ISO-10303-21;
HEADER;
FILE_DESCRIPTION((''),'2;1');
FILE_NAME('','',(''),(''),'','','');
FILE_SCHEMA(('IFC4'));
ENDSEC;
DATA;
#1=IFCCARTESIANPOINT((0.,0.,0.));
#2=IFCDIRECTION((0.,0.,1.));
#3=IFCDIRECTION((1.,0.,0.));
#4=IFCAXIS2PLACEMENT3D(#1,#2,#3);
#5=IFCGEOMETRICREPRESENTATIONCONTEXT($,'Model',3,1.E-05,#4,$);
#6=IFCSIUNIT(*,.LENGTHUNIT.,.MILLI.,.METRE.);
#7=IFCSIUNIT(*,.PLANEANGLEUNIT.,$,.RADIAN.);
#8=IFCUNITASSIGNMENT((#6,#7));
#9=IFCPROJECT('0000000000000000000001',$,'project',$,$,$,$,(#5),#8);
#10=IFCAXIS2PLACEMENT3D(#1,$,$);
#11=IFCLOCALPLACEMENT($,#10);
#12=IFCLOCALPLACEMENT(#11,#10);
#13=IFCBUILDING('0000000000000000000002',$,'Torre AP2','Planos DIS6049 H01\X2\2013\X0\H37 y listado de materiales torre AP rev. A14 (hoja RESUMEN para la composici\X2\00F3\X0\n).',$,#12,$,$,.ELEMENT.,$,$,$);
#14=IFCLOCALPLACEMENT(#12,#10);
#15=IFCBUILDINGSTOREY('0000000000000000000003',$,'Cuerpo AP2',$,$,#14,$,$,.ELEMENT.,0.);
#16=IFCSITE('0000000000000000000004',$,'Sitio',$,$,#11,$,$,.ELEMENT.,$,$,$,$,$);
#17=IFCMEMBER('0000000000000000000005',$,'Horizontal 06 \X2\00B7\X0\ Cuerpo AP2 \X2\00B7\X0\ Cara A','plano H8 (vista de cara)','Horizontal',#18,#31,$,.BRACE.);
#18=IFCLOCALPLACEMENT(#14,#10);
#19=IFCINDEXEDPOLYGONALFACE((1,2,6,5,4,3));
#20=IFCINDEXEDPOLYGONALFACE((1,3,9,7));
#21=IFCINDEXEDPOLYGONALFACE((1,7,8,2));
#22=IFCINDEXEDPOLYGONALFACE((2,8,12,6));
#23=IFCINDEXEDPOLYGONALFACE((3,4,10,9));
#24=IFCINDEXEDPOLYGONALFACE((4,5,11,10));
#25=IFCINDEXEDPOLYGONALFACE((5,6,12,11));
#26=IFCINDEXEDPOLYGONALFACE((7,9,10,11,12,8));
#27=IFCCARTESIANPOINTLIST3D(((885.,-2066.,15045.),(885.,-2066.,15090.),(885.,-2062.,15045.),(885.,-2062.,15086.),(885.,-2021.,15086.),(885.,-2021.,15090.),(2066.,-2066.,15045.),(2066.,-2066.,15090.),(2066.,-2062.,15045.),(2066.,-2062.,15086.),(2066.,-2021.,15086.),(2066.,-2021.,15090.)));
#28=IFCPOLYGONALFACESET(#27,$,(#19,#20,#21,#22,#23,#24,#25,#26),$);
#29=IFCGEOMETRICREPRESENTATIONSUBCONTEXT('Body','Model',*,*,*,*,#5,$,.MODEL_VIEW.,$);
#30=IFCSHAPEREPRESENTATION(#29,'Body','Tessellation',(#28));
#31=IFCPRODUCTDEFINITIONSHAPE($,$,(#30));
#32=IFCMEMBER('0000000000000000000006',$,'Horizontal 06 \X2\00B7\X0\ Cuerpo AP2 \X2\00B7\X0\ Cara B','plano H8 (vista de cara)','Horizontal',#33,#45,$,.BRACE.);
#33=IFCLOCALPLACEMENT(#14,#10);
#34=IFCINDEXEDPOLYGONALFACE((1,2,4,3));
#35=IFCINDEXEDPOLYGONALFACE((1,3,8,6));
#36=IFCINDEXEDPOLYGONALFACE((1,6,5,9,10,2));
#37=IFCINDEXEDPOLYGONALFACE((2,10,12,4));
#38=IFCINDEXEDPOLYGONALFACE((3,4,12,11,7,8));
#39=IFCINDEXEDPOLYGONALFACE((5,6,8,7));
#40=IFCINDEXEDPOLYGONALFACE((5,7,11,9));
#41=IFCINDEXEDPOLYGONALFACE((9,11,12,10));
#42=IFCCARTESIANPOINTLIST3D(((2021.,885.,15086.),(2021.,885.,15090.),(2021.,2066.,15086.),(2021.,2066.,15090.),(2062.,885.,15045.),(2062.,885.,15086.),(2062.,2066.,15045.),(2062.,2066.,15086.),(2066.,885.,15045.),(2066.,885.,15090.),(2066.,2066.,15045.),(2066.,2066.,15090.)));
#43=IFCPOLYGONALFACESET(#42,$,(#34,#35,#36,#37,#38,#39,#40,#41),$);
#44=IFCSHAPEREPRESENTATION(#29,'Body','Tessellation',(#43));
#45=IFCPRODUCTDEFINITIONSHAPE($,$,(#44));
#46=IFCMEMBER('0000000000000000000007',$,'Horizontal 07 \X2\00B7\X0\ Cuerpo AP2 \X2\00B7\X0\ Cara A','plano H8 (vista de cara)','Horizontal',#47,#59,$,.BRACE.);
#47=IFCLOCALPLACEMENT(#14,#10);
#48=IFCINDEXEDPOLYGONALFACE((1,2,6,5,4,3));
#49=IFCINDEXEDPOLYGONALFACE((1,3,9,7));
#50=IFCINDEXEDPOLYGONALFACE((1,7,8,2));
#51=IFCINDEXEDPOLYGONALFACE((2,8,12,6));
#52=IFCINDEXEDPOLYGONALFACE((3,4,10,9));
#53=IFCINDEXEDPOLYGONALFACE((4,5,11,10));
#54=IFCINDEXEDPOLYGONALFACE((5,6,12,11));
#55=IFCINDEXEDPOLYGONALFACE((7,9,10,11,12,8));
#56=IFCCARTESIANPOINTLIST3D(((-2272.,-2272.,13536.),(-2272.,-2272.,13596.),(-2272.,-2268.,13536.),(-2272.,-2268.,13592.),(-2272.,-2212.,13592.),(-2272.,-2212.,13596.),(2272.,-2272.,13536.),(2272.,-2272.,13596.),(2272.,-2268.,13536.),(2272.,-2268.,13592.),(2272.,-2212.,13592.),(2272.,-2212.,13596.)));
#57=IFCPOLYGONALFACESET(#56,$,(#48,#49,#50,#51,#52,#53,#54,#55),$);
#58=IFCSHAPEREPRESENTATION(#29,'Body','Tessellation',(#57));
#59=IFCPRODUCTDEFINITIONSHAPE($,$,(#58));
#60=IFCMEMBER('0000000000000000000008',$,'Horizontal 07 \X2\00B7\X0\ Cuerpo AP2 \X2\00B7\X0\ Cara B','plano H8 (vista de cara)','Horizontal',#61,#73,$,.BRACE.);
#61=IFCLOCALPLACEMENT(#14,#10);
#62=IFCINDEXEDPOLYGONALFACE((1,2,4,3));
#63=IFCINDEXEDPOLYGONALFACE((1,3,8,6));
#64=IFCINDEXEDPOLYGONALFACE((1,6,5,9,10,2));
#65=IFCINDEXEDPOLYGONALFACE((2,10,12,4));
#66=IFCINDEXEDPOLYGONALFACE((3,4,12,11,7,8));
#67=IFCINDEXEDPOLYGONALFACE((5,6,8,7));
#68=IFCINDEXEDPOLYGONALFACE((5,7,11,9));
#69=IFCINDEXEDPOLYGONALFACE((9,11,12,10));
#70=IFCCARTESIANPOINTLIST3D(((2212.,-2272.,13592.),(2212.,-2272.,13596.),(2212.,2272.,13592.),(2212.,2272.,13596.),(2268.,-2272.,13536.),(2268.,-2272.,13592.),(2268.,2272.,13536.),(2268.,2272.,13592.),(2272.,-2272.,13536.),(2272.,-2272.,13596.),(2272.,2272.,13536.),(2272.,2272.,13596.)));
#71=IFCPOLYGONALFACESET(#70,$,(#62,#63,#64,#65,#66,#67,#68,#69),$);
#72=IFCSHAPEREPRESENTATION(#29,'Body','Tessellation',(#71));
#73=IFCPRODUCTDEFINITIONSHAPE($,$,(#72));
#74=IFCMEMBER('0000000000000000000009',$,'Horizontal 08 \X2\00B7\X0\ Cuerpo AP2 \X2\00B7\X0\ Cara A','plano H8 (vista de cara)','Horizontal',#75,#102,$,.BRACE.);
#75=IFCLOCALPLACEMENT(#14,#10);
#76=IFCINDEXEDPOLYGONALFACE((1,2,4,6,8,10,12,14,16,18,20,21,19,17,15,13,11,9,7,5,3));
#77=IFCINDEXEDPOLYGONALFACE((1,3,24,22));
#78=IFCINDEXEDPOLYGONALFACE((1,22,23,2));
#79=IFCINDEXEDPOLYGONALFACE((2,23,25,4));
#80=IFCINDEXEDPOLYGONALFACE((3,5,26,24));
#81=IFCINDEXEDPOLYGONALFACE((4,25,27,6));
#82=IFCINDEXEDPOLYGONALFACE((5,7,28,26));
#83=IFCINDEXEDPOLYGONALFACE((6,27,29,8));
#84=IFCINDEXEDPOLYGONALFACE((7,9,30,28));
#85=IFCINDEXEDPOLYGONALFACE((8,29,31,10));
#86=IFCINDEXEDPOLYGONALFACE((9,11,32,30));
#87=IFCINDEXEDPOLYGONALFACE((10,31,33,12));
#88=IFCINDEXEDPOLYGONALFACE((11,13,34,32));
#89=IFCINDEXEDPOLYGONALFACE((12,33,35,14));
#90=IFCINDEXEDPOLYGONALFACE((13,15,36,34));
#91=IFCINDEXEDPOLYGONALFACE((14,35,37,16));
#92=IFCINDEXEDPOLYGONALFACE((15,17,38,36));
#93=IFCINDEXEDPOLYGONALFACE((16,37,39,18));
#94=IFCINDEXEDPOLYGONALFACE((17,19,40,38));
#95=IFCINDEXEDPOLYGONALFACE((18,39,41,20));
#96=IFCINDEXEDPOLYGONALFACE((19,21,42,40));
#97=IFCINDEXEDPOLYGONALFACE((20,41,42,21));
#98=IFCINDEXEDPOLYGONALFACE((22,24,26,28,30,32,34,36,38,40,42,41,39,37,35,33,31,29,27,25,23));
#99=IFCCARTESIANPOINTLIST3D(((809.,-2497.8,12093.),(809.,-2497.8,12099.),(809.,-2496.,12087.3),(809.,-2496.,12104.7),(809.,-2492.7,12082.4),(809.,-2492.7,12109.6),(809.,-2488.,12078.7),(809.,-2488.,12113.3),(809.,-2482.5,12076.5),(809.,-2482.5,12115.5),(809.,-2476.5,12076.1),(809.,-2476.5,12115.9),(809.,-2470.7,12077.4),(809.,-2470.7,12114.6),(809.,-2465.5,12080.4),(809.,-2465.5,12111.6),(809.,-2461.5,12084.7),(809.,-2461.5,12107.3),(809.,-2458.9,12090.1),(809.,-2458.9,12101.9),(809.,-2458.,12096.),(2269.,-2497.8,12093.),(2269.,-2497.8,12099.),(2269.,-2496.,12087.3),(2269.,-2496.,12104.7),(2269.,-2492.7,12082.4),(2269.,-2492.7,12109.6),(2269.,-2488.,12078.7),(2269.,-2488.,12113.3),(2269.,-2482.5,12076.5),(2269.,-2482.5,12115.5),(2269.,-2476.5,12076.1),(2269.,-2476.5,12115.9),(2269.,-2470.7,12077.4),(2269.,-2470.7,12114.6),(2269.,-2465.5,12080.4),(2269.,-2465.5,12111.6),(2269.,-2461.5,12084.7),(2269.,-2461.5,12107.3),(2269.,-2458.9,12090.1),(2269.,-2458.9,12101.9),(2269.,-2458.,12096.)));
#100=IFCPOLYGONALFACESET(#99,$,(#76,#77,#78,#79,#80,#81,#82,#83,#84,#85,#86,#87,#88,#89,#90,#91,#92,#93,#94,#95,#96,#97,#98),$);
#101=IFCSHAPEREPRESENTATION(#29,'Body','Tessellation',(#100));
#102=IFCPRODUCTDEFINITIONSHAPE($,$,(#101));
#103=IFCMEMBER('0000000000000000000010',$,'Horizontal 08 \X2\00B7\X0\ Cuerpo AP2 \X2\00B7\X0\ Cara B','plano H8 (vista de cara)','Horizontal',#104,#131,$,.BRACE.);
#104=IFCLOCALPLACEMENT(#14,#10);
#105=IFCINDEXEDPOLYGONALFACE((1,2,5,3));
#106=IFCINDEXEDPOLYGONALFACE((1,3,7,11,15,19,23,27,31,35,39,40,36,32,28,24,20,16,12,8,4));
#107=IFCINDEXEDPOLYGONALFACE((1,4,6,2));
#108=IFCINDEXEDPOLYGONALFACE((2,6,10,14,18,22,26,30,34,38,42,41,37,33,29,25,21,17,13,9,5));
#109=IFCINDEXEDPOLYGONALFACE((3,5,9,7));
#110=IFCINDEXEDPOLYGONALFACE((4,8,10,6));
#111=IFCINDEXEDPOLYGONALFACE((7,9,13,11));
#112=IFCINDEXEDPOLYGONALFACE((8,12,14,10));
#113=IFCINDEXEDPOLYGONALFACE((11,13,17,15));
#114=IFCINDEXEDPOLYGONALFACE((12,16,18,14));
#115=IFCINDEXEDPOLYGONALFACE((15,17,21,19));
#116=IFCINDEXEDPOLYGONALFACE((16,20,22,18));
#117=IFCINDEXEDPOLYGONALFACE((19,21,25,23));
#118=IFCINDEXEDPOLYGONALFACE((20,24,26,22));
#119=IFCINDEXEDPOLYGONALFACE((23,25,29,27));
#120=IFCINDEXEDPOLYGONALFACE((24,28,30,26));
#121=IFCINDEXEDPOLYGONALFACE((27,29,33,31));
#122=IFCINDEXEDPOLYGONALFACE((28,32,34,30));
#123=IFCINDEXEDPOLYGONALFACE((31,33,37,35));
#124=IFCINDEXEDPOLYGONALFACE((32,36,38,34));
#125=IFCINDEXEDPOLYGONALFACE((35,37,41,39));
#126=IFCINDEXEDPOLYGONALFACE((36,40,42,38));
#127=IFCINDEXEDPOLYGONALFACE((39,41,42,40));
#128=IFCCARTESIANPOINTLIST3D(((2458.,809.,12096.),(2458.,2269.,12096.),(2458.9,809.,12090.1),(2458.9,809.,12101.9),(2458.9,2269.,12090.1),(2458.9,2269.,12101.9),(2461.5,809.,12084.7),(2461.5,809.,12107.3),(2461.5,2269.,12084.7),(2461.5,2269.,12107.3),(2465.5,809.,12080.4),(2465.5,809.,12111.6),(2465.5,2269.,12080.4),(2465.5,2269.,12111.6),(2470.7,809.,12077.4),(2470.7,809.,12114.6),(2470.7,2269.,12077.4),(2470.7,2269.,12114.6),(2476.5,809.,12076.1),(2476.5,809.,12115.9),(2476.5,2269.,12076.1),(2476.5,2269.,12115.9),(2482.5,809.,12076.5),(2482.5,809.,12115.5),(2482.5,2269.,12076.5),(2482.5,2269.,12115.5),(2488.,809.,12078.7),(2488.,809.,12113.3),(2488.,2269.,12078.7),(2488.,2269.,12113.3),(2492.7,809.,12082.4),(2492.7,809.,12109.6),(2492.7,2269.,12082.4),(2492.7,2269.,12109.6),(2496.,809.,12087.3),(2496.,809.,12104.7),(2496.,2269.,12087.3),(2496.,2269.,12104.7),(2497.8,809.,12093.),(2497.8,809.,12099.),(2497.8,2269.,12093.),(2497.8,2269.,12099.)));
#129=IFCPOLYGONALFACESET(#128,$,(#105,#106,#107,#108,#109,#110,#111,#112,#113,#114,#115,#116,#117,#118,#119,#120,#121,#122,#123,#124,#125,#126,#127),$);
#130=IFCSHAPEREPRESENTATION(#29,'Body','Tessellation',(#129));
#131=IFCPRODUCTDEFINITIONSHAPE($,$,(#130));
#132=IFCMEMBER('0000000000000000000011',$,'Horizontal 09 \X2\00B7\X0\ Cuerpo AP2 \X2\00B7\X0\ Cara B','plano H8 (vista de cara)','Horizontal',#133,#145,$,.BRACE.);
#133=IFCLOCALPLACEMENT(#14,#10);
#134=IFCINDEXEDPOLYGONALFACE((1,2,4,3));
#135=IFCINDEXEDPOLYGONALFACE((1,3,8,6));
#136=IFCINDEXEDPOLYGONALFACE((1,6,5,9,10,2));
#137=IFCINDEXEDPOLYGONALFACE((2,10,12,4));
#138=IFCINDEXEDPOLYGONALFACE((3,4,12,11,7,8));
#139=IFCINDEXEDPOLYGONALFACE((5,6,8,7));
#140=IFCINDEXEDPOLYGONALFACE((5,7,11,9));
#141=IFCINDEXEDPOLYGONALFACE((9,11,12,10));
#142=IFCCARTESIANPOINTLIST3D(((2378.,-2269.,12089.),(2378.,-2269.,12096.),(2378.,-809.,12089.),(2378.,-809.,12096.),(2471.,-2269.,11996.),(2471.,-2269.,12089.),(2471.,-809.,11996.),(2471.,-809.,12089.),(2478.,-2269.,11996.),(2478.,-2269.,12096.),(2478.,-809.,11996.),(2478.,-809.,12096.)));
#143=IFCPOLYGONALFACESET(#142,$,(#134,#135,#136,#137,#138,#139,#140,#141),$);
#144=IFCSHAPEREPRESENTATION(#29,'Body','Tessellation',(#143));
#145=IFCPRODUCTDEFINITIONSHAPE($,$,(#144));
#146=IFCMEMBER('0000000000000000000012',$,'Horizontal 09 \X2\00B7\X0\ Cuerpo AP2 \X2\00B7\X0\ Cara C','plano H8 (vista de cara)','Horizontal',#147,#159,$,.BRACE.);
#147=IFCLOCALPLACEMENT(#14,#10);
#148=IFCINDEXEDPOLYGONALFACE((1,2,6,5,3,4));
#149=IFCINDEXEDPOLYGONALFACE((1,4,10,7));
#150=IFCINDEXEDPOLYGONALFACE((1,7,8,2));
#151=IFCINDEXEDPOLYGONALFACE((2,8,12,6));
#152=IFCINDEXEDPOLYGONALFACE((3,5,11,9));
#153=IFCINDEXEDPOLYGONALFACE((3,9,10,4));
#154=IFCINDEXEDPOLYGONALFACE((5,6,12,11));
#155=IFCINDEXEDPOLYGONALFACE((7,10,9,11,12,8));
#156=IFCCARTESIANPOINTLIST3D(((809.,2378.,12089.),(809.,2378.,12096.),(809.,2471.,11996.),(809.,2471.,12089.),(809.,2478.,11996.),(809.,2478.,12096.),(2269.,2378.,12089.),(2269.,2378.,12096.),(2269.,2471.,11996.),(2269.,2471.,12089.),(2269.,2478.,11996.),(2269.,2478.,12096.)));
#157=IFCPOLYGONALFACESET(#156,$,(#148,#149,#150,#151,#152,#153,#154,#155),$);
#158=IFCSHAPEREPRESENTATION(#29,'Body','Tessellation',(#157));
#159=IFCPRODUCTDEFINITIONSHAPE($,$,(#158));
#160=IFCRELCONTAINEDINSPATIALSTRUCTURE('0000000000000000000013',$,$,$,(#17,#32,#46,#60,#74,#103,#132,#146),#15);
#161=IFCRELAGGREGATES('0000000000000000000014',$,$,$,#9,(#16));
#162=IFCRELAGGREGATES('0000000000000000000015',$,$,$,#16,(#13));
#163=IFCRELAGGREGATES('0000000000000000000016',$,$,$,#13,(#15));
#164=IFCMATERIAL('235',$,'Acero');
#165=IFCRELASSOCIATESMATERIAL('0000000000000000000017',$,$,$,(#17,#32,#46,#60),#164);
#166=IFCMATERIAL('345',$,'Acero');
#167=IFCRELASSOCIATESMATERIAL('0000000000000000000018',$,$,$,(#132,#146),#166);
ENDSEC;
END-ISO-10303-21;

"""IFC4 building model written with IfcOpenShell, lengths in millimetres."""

from ifc_helpers import new_model, si_unit, frame, frame_2d, origin, origin_with_axes, place, context, subcontext, project, spatial, circle, l_section, extrude, material, element, save


model = new_model("IFC4")

# Units and contexts
model_context = context("Model", 3, precision=1e-05, world=origin_with_axes())
body_context = subcontext(model_context, "Body", "Model", "MODEL_VIEW")
ifc_project = project(units=[si_unit("LENGTHUNIT", "METRE", prefix="MILLI"), si_unit("PLANEANGLEUNIT", "RADIAN")], contexts=[model_context])

# Site, building, storey
site_placement = place(None, origin())
site = spatial("IfcSite", under=ifc_project, at=site_placement, Name="Sitio", CompositionType="ELEMENT")
building_placement = place(site_placement, origin())
building = spatial("IfcBuilding", under=site, at=building_placement, Name="Torre AP2", Description="Planos DIS6049 H01–H37 y listado de materiales torre AP rev. A14 (hoja RESUMEN para la composición).", CompositionType="ELEMENT")
storey_placement = place(building_placement, origin())
storey = spatial("IfcBuildingStorey", under=building, at=storey_placement, Name="Cuerpo AP2", CompositionType="ELEMENT", Elevation=0.0)

# Members
ifc_material_1 = material(Name="345", Category="Acero")
ifc_material_2 = material(Name="235", Category="Acero")
for number, where, z_axis, x_axis, name in (
    (1, (2066.0, -2066.0, 15090.0), (-1.0, 0.0, 0.0), (0.0, 1.0, 0.0), "Horizontal 06 · Cuerpo AP2 · Cara A"),
    (2, (2066.0, 2066.0, 15090.0), (0.0, -1.0, 0.0), (-1.0, 0.0, 0.0), "Horizontal 06 · Cuerpo AP2 · Cara B"),
):
    element("IfcMember", number, at=place(storey_placement, frame(where, z_axis=z_axis, x_axis=x_axis)), inside=storey, material=ifc_material_2, Name=name, Description="plano H8 (vista de cara)", ObjectType="Horizontal", PredefinedType="BRACE", context=body_context, shape_type="SweptSolid", body=[
        extrude(l_section(Depth=45.0, Width=45.0, Thickness=4.0, at=frame_2d((22.5, 22.5))), None, (0.0, 0.0, 1.0), 1181.0),
    ])
for number, where, z_axis, x_axis, name in (
    (3, (2272.0, -2272.0, 13596.0), (-1.0, 0.0, 0.0), (0.0, 1.0, 0.0), "Horizontal 07 · Cuerpo AP2 · Cara A"),
    (4, (2272.0, 2272.0, 13596.0), (0.0, -1.0, 0.0), (-1.0, 0.0, 0.0), "Horizontal 07 · Cuerpo AP2 · Cara B"),
):
    element("IfcMember", number, at=place(storey_placement, frame(where, z_axis=z_axis, x_axis=x_axis)), inside=storey, material=ifc_material_2, Name=name, Description="plano H8 (vista de cara)", ObjectType="Horizontal", PredefinedType="BRACE", context=body_context, shape_type="SweptSolid", body=[
        extrude(l_section(Depth=60.0, Width=60.0, Thickness=4.0, at=frame_2d((30.0, 30.0))), None, (0.0, 0.0, 1.0), 4544.0),
    ])
for number, where, z_axis, x_axis, name in (
    (5, (2269.0, -2478.0, 12096.0), (-1.0, 0.0, 0.0), (0.0, 1.0, 0.0), "Horizontal 08 · Cuerpo AP2 · Cara A"),
    (6, (2478.0, 2269.0, 12096.0), (0.0, -1.0, 0.0), (-1.0, 0.0, 0.0), "Horizontal 08 · Cuerpo AP2 · Cara B"),
):
    element("IfcMember", number, at=place(storey_placement, frame(where, z_axis=z_axis, x_axis=x_axis)), inside=storey, Name=name, Description="plano H8 (vista de cara)", ObjectType="Horizontal", PredefinedType="BRACE", context=body_context, shape_type="SweptSolid", body=[
        extrude(circle(Radius=20.0), None, (0.0, 0.0, 1.0), 1460.0),
    ])
for number, where, z_axis, x_axis, name in (
    (7, (2478.0, -809.0, 12096.0), (0.0, -1.0, 0.0), (-1.0, 0.0, 0.0), "Horizontal 09 · Cuerpo AP2 · Cara B"),
    (8, (809.0, 2478.0, 12096.0), (1.0, 0.0, 0.0), (0.0, -1.0, 0.0), "Horizontal 09 · Cuerpo AP2 · Cara C"),
):
    element("IfcMember", number, at=place(storey_placement, frame(where, z_axis=z_axis, x_axis=x_axis)), inside=storey, material=ifc_material_1, Name=name, Description="plano H8 (vista de cara)", ObjectType="Horizontal", PredefinedType="BRACE", context=body_context, shape_type="SweptSolid", body=[
        extrude(l_section(Depth=100.0, Width=100.0, Thickness=7.0, at=frame_2d((50.0, 50.0))), None, (0.0, 0.0, 1.0), 1460.0),
    ])

save(model, "model.ifc")
